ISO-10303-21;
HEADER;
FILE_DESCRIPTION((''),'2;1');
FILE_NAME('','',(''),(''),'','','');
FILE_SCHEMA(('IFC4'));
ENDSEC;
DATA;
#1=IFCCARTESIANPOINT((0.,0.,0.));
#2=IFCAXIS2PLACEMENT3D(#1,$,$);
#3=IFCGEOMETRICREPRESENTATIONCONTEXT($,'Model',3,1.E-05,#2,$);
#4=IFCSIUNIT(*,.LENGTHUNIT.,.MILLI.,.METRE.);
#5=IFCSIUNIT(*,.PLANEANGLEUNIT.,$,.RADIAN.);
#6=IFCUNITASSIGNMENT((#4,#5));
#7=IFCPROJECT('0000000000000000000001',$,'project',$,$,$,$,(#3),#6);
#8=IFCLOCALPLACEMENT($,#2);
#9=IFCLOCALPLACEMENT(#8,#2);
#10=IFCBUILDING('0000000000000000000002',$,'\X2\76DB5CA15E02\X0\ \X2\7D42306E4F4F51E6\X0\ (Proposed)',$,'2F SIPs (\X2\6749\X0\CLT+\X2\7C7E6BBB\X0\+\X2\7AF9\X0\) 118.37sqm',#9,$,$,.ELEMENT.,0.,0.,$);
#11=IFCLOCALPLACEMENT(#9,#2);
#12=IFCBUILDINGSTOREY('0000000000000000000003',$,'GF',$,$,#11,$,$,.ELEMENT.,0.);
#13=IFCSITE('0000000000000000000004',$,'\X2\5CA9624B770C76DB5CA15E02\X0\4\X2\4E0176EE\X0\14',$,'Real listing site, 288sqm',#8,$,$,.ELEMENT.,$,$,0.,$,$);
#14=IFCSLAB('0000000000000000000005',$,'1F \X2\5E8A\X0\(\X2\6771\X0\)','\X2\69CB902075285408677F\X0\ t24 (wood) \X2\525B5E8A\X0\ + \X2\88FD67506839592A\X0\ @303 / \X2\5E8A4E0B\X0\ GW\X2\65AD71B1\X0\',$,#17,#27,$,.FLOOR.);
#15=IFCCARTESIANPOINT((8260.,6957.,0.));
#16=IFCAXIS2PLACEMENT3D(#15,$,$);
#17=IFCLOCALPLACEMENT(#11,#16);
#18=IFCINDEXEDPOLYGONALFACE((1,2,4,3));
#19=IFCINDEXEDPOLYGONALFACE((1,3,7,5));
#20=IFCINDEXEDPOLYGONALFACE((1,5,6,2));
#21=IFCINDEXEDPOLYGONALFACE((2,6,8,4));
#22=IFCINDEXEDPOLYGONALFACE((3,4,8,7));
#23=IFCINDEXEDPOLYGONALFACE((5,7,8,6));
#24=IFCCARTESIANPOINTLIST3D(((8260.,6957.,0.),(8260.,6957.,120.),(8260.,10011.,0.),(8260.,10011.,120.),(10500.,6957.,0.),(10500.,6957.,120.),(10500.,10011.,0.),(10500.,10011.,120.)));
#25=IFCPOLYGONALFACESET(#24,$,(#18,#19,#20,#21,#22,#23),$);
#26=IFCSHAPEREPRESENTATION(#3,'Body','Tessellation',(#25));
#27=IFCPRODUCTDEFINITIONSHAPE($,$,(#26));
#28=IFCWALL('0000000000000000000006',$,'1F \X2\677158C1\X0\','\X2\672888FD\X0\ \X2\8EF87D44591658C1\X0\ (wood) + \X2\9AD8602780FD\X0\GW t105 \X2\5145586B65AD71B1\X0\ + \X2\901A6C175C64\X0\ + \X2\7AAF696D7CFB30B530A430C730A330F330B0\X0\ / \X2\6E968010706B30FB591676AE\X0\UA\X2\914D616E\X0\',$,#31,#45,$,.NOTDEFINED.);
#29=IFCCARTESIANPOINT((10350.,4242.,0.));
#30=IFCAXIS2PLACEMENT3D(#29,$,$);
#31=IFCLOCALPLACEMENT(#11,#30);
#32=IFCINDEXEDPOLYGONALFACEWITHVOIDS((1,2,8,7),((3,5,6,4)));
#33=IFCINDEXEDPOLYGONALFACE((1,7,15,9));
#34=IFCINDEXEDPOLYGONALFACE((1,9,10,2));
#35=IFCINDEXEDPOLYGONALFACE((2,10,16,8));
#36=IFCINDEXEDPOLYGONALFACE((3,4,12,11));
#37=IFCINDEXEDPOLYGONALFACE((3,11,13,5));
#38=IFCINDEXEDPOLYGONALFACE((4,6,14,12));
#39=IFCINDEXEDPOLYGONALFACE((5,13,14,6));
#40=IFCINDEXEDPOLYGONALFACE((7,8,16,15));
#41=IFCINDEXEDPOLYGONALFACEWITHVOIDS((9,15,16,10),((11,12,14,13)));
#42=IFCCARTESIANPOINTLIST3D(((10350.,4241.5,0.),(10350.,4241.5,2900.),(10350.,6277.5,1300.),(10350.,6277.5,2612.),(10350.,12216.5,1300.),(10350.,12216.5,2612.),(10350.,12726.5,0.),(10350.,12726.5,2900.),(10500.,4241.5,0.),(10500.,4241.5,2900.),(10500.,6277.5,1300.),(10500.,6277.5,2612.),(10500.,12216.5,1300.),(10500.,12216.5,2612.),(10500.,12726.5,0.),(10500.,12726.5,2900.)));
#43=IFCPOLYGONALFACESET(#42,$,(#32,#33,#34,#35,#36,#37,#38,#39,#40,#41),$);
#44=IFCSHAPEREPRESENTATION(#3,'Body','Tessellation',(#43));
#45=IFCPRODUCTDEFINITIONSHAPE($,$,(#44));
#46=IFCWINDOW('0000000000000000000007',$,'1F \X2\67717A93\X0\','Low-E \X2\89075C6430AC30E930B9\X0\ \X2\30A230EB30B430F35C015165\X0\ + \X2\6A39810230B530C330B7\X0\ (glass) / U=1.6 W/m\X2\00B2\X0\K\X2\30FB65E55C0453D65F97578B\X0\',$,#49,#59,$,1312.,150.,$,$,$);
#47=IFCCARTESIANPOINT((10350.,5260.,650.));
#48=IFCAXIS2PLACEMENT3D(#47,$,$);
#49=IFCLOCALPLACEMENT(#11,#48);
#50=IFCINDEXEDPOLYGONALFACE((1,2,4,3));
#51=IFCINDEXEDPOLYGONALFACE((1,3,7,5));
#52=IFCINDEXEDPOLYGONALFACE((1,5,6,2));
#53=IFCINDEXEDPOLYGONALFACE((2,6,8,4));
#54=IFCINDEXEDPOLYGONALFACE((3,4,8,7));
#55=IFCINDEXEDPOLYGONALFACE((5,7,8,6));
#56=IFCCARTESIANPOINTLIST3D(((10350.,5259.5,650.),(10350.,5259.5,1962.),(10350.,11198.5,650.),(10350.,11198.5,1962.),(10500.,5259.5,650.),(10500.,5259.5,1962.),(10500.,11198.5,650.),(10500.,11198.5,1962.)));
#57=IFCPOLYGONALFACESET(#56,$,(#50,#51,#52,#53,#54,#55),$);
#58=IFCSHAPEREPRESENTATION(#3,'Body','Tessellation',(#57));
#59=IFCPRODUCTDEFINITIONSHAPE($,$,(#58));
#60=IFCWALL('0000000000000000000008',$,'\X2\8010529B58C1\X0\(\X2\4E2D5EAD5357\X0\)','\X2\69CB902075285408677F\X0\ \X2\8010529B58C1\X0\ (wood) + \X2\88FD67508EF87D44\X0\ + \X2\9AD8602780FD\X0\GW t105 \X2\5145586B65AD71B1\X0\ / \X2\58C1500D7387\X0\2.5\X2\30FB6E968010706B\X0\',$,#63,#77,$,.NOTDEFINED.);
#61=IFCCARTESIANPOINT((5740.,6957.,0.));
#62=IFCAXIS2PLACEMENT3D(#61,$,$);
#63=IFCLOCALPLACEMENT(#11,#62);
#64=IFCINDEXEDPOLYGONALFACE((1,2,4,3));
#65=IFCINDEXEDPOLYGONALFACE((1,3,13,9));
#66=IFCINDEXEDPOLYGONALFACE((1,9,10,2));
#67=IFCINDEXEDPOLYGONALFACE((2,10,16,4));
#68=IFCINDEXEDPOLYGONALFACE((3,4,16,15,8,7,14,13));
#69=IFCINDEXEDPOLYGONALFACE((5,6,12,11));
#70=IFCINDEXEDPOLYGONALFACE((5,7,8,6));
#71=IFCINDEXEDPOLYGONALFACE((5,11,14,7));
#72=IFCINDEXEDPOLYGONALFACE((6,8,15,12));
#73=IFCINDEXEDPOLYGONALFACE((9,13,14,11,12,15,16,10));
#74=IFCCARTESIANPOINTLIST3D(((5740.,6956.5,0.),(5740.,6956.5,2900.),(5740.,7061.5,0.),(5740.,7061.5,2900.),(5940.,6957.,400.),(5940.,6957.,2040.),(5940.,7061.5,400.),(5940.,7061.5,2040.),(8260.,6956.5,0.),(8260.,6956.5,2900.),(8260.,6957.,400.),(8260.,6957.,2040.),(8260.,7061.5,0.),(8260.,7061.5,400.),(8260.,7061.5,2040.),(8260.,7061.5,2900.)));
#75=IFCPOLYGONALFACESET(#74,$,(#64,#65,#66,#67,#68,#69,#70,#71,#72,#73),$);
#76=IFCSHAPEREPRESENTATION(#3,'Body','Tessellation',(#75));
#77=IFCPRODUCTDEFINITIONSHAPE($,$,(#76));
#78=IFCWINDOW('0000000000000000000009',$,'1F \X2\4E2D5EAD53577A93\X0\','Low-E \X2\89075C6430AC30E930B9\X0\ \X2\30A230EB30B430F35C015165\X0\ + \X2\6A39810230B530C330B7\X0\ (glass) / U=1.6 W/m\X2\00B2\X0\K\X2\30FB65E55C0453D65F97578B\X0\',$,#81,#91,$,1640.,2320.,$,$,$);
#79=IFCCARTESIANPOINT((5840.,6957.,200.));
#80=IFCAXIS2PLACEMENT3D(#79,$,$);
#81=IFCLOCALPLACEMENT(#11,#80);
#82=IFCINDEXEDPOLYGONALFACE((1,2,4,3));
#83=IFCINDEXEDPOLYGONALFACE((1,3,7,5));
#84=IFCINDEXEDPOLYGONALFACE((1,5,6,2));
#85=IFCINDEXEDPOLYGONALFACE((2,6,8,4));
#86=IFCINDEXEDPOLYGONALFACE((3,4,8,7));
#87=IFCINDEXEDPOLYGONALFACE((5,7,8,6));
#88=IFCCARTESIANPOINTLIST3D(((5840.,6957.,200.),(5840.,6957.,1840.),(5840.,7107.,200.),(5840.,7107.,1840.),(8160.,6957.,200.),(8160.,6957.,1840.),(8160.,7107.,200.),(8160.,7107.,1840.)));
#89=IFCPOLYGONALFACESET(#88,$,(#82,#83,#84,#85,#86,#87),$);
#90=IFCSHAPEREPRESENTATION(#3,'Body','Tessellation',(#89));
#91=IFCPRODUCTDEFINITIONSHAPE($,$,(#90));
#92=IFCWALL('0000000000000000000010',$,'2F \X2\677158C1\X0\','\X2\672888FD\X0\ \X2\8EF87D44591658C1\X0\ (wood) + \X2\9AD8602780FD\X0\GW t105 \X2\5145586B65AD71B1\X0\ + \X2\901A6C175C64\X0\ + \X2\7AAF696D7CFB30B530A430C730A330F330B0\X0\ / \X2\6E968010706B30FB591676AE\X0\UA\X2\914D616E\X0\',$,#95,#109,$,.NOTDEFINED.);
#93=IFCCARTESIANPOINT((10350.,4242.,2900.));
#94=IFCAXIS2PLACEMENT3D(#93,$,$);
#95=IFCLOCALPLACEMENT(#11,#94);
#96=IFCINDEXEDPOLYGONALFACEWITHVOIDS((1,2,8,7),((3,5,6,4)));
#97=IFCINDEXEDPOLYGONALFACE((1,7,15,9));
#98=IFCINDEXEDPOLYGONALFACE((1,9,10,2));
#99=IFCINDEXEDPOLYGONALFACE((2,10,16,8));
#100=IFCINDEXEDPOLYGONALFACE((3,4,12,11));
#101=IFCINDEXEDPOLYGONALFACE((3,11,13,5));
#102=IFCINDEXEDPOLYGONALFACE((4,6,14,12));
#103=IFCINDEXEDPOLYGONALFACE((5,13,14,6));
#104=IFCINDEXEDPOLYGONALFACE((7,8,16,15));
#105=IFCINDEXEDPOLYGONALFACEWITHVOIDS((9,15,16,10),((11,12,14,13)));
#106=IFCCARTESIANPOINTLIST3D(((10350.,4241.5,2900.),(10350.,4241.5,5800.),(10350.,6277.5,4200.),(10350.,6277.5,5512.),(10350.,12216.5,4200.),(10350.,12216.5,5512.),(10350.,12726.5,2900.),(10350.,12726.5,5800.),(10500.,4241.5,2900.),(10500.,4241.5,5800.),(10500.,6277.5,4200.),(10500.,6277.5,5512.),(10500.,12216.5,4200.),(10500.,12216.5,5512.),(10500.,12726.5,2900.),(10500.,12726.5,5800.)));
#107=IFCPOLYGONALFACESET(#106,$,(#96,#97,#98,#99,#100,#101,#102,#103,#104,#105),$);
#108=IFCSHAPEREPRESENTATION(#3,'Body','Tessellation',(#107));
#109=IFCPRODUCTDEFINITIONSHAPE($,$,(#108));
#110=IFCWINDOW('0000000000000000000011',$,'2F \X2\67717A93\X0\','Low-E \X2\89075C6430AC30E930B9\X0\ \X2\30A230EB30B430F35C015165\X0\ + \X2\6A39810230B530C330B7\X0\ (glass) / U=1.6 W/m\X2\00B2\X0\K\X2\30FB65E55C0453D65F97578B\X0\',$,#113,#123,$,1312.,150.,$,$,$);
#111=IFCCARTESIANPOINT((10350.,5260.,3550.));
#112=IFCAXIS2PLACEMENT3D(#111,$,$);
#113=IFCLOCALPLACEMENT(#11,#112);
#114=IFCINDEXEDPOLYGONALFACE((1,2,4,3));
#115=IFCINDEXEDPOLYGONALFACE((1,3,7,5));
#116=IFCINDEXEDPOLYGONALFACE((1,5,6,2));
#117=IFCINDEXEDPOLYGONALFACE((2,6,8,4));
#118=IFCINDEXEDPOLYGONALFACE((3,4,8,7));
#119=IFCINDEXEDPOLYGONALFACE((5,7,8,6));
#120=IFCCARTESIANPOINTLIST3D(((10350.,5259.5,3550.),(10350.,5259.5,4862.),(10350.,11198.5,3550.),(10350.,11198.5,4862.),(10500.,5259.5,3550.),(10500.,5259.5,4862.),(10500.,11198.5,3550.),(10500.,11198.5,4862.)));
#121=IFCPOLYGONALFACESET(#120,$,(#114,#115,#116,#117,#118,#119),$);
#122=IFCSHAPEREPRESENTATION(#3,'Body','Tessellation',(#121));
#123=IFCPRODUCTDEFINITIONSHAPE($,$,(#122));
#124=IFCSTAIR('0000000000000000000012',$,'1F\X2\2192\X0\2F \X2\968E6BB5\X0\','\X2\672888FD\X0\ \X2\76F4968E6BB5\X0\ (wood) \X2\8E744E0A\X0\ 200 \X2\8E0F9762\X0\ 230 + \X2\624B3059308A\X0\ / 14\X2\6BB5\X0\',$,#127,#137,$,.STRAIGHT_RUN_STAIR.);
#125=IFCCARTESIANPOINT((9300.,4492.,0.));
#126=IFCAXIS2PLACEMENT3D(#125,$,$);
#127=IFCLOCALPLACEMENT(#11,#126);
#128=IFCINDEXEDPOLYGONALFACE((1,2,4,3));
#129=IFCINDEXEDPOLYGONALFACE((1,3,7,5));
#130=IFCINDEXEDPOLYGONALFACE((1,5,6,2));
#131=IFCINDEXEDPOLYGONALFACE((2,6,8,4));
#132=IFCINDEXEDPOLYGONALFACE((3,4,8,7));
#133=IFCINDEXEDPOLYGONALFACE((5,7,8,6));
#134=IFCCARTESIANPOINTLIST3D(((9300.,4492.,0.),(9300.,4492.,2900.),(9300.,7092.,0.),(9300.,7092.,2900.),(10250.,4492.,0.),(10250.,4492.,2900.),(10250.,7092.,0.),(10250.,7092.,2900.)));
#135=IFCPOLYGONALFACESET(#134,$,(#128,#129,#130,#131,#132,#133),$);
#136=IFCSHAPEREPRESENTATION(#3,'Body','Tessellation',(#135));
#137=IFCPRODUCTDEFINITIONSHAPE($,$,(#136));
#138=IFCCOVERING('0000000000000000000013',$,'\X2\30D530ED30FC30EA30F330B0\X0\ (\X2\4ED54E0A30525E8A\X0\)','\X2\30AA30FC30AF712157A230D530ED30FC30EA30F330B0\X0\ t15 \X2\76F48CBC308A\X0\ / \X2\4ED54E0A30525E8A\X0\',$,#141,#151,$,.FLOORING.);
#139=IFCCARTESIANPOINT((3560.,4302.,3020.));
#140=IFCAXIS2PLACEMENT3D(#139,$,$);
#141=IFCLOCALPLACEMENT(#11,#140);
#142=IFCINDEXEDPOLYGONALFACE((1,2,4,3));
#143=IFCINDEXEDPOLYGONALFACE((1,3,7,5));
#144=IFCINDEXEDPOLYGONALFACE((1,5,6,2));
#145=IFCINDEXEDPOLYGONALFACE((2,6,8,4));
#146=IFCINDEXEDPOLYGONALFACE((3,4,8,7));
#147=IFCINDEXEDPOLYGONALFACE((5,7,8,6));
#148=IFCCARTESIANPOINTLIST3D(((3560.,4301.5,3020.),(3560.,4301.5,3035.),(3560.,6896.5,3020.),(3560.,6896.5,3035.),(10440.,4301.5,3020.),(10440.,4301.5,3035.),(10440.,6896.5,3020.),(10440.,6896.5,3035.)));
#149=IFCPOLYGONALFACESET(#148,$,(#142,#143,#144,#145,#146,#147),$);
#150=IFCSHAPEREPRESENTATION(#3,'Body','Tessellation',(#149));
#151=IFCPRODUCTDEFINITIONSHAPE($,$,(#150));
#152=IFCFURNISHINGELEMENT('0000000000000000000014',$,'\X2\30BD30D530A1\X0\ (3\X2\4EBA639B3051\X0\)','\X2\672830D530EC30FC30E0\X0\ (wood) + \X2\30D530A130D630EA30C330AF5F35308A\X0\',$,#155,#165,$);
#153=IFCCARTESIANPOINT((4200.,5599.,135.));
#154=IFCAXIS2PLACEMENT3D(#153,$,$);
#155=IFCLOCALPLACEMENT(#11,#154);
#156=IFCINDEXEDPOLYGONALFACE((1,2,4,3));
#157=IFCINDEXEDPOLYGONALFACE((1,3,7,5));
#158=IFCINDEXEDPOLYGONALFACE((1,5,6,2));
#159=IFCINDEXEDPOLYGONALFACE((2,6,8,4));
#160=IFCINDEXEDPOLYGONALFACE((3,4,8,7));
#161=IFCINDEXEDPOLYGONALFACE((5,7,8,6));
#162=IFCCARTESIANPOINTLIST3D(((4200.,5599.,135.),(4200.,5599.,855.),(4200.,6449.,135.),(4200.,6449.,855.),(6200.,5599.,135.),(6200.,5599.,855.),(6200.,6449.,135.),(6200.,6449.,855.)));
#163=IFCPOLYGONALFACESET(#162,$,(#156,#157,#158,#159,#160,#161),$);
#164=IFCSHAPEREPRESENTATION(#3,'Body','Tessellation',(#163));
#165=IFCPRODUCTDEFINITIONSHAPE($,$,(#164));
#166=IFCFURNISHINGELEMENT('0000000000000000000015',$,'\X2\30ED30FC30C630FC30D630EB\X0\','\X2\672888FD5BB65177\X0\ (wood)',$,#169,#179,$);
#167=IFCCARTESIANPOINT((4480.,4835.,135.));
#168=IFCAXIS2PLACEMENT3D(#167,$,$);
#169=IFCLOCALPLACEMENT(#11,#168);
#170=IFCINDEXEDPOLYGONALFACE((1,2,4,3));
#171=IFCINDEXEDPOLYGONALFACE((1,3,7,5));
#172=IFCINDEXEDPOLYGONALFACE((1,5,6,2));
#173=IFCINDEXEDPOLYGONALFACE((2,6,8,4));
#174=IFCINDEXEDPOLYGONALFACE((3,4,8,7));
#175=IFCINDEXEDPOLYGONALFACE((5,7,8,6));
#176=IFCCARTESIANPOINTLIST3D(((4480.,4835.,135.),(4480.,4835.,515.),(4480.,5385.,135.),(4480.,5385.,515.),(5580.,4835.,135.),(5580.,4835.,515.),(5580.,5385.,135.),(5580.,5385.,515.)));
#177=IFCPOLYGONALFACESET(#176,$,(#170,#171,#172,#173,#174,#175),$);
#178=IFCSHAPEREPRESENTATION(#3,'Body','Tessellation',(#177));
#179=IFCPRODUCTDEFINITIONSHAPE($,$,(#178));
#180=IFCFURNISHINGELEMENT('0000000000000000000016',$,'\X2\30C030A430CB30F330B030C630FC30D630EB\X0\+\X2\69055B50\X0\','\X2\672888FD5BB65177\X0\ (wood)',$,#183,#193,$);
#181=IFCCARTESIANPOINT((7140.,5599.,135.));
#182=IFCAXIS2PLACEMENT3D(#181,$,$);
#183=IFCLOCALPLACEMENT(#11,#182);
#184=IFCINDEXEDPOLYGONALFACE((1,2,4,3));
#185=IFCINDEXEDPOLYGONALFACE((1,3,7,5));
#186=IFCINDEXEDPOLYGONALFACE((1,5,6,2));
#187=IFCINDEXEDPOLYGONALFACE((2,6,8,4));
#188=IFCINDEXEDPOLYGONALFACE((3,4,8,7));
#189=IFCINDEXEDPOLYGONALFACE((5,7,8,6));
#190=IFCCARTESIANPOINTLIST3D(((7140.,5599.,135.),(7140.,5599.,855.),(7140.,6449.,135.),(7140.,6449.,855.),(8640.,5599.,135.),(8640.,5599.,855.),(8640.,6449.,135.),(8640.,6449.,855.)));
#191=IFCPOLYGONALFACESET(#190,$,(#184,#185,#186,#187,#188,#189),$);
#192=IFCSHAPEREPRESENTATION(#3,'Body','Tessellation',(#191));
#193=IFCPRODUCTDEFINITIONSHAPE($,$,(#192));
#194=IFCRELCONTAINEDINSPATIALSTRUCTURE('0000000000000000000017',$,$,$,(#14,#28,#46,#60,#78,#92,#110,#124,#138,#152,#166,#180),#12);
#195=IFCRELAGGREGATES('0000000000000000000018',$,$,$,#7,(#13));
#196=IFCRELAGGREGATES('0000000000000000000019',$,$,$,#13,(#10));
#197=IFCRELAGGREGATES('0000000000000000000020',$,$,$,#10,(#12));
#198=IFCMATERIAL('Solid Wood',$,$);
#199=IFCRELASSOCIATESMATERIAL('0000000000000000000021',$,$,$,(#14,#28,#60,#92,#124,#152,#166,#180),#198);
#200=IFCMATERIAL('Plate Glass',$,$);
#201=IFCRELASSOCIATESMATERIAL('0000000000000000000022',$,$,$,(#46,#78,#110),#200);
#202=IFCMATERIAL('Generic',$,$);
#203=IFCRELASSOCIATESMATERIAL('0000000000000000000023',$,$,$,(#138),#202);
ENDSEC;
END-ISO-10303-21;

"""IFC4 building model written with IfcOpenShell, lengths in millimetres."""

from ifc_helpers import new_model, si_unit, frame, frame_2d, origin, place, context, project, spatial, rectangle, extrude, material, element, fill, save


model = new_model("IFC4")

# Units and contexts
model_context = context("Model", 3, precision=1e-05, world=origin())
ifc_project = project(units=[si_unit("LENGTHUNIT", "METRE", prefix="MILLI"), si_unit("PLANEANGLEUNIT", "RADIAN")], contexts=[model_context])

# Site, building, storey
site_placement = place(None, origin())
site = spatial("IfcSite", under=ifc_project, at=site_placement, Name="岩手県盛岡市4丁目14", ObjectType="Real listing site, 288sqm", CompositionType="ELEMENT", RefElevation=0.0)
building_placement = place(site_placement, origin())
building = spatial("IfcBuilding", under=site, at=building_placement, Name="盛岡市 終の住処 (Proposed)", ObjectType="2F SIPs (杉CLT+籾殻+竹) 118.37sqm", CompositionType="ELEMENT", ElevationOfRefHeight=0.0, ElevationOfTerrain=0.0)
storey_placement = place(building_placement, origin())
storey = spatial("IfcBuildingStorey", under=building, at=storey_placement, Name="GF", CompositionType="ELEMENT", Elevation=0.0)

# Slab
ifc_material_1 = material(Name="Solid Wood")
slab_placement = place(storey_placement, frame((8260.0, 6957.0, 0.0)))
element("IfcSlab", 1, at=slab_placement, inside=storey, material=ifc_material_1, Name="1F 床(東)", Description="構造用合板 t24 (wood) 剛床 + 製材根太 @303 / 床下 GW断熱", PredefinedType="FLOOR", context=model_context, shape_type="SweptSolid", body=[
    extrude(rectangle(XDim=2240.0, YDim=3054.0, at=frame_2d((1120.0, 1527.0))), frame((8260.0, 6957.0, 0.0)), (0.0, 0.0, 1.0), 120.0),
])

# Walls, openings, windows
wall_1_placement = place(storey_placement, frame((10350.0, 4242.0, 0.0)))
wall_1 = element("IfcWall", 2, at=wall_1_placement, inside=storey, material=ifc_material_1, Name="1F 東壁", Description="木製 軸組外壁 (wood) + 高性能GW t105 充填断熱 + 通気層 + 窯業系サイディング / 準耐火・外皮UA配慮", PredefinedType="NOTDEFINED", context=model_context, shape_type="SweptSolid", body=[
    extrude(rectangle(XDim=150.0, YDim=8485.0, at=frame_2d((75.0, 4242.0))), frame((10350.0, 4242.0, 0.0)), (0.0, 0.0, 1.0), 2900.0),
])
opening_1_placement = place(storey_placement, frame((10350.0, 5260.0, 650.0)))
opening_1 = element("IfcOpeningElement", 3, at=opening_1_placement, cuts=wall_1, PredefinedType="NOTDEFINED", context=model_context, shape_type="SweptSolid", body=[
    extrude(rectangle(XDim=150.0, YDim=5939.0, at=frame_2d((75.0, 2969.0))), frame((10350.0, 5260.0, 650.0)), (0.0, 0.0, 1.0), 1312.0),
])
ifc_material_2 = material(Name="Plate Glass")
window_1_placement = place(storey_placement, frame((10350.0, 5260.0, 650.0)))
window_1 = element("IfcWindow", 4, at=window_1_placement, inside=storey, material=ifc_material_2, Name="1F 東窓", Description="Low-E 複層ガラス アルゴン封入 + 樹脂サッシ (glass) / U=1.6 W/m²K・日射取得型", OverallHeight=1312.0, OverallWidth=150.0, context=model_context, shape_type="SweptSolid", body=[
    extrude(rectangle(XDim=150.0, YDim=5939.0, at=frame_2d((75.0, 2969.0))), frame((10350.0, 5260.0, 650.0)), (0.0, 0.0, 1.0), 1312.0),
])
fill(opening_1, window_1)
wall_2_placement = place(storey_placement, frame((5740.0, 6957.0, 0.0)))
wall_2 = element("IfcWall", 5, at=wall_2_placement, inside=storey, material=ifc_material_1, Name="耐力壁(中庭南)", Description="構造用合板 耐力壁 (wood) + 製材軸組 + 高性能GW t105 充填断熱 / 壁倍率2.5・準耐火", PredefinedType="NOTDEFINED", context=model_context, shape_type="SweptSolid", body=[
    extrude(rectangle(XDim=2520.0, YDim=105.0, at=frame_2d((1260.0, 52.0))), frame((5740.0, 6957.0, 0.0)), (0.0, 0.0, 1.0), 2900.0),
])
opening_2_placement = place(storey_placement, frame((5840.0, 6957.0, 200.0)))
opening_2 = element("IfcOpeningElement", 6, at=opening_2_placement, cuts=wall_2, PredefinedType="NOTDEFINED", context=model_context, shape_type="SweptSolid", body=[
    extrude(rectangle(XDim=2320.0, YDim=150.0, at=frame_2d((1160.0, 75.0))), frame((5840.0, 6957.0, 200.0)), (0.0, 0.0, 1.0), 1640.0),
])
window_2_placement = place(storey_placement, frame((5840.0, 6957.0, 200.0)))
window_2 = element("IfcWindow", 7, at=window_2_placement, inside=storey, material=ifc_material_2, Name="1F 中庭南窓", Description="Low-E 複層ガラス アルゴン封入 + 樹脂サッシ (glass) / U=1.6 W/m²K・日射取得型", OverallHeight=1640.0, OverallWidth=2320.0, context=model_context, shape_type="SweptSolid", body=[
    extrude(rectangle(XDim=2320.0, YDim=150.0, at=frame_2d((1160.0, 75.0))), frame((5840.0, 6957.0, 200.0)), (0.0, 0.0, 1.0), 1640.0),
])
fill(opening_2, window_2)

# Wall, opening, window
wall_3_placement = place(storey_placement, frame((10350.0, 4242.0, 2900.0)))
wall_3 = element("IfcWall", 8, at=wall_3_placement, inside=storey, material=ifc_material_1, Name="2F 東壁", Description="木製 軸組外壁 (wood) + 高性能GW t105 充填断熱 + 通気層 + 窯業系サイディング / 準耐火・外皮UA配慮", PredefinedType="NOTDEFINED", context=model_context, shape_type="SweptSolid", body=[
    extrude(rectangle(XDim=150.0, YDim=8485.0, at=frame_2d((75.0, 4242.0))), frame((10350.0, 4242.0, 2900.0)), (0.0, 0.0, 1.0), 2900.0),
])
opening_3_placement = place(storey_placement, frame((10350.0, 5260.0, 3550.0)))
opening_3 = element("IfcOpeningElement", 9, at=opening_3_placement, cuts=wall_3, PredefinedType="NOTDEFINED", context=model_context, shape_type="SweptSolid", body=[
    extrude(rectangle(XDim=150.0, YDim=5939.0, at=frame_2d((75.0, 2969.0))), frame((10350.0, 5260.0, 3550.0)), (0.0, 0.0, 1.0), 1312.0),
])
window_3_placement = place(storey_placement, frame((10350.0, 5260.0, 3550.0)))
window_3 = element("IfcWindow", 10, at=window_3_placement, inside=storey, material=ifc_material_2, Name="2F 東窓", Description="Low-E 複層ガラス アルゴン封入 + 樹脂サッシ (glass) / U=1.6 W/m²K・日射取得型", OverallHeight=1312.0, OverallWidth=150.0, context=model_context, shape_type="SweptSolid", body=[
    extrude(rectangle(XDim=150.0, YDim=5939.0, at=frame_2d((75.0, 2969.0))), frame((10350.0, 5260.0, 3550.0)), (0.0, 0.0, 1.0), 1312.0),
])
fill(opening_3, window_3)

# Stair
stair_placement = place(storey_placement, frame((9300.0, 4492.0, 0.0)))
element("IfcStair", 11, at=stair_placement, inside=storey, material=ifc_material_1, Name="1F→2F 階段", Description="木製 直階段 (wood) 蹴上 200 踏面 230 + 手すり / 14段", PredefinedType="STRAIGHT_RUN_STAIR", context=model_context, shape_type="SweptSolid", body=[
    extrude(rectangle(XDim=950.0, YDim=2600.0, at=frame_2d((475.0, 1300.0))), frame((9300.0, 4492.0, 0.0)), (0.0, 0.0, 1.0), 2900.0),
])

# Covering
ifc_material_3 = material(Name="Generic")
covering_placement = place(storey_placement, frame((3560.0, 4302.0, 3020.0)))
element("IfcCovering", 12, at=covering_placement, inside=storey, material=ifc_material_3, Name="フローリング (仕上げ床)", Description="オーク無垢フローリング t15 直貼り / 仕上げ床", PredefinedType="FLOORING", context=model_context, shape_type="SweptSolid", body=[
    extrude(rectangle(XDim=6880.0, YDim=2595.0, at=frame_2d((3440.0, 1297.0))), frame((3560.0, 4302.0, 3020.0)), (0.0, 0.0, 1.0), 15.0),
])

# Furnishing elements
furnishing_1_placement = place(storey_placement, frame((4200.0, 5599.0, 135.0)))
element("IfcFurnishingElement", 13, at=furnishing_1_placement, inside=storey, material=ifc_material_1, Name="ソファ (3人掛け)", Description="木フレーム (wood) + ファブリック張り", context=model_context, shape_type="SweptSolid", body=[
    extrude(rectangle(XDim=2000.0, YDim=850.0, at=frame_2d((1000.0, 425.0))), frame((4200.0, 5599.0, 135.0)), (0.0, 0.0, 1.0), 720.0),
])
furnishing_2_placement = place(storey_placement, frame((4480.0, 4835.0, 135.0)))
element("IfcFurnishingElement", 14, at=furnishing_2_placement, inside=storey, material=ifc_material_1, Name="ローテーブル", Description="木製家具 (wood)", context=model_context, shape_type="SweptSolid", body=[
    extrude(rectangle(XDim=1100.0, YDim=550.0, at=frame_2d((550.0, 275.0))), frame((4480.0, 4835.0, 135.0)), (0.0, 0.0, 1.0), 380.0),
])
furnishing_3_placement = place(storey_placement, frame((7140.0, 5599.0, 135.0)))
element("IfcFurnishingElement", 15, at=furnishing_3_placement, inside=storey, material=ifc_material_1, Name="ダイニングテーブル+椅子", Description="木製家具 (wood)", context=model_context, shape_type="SweptSolid", body=[
    extrude(rectangle(XDim=1500.0, YDim=850.0, at=frame_2d((750.0, 425.0))), frame((7140.0, 5599.0, 135.0)), (0.0, 0.0, 1.0), 720.0),
])

save(model, "model.ifc")
